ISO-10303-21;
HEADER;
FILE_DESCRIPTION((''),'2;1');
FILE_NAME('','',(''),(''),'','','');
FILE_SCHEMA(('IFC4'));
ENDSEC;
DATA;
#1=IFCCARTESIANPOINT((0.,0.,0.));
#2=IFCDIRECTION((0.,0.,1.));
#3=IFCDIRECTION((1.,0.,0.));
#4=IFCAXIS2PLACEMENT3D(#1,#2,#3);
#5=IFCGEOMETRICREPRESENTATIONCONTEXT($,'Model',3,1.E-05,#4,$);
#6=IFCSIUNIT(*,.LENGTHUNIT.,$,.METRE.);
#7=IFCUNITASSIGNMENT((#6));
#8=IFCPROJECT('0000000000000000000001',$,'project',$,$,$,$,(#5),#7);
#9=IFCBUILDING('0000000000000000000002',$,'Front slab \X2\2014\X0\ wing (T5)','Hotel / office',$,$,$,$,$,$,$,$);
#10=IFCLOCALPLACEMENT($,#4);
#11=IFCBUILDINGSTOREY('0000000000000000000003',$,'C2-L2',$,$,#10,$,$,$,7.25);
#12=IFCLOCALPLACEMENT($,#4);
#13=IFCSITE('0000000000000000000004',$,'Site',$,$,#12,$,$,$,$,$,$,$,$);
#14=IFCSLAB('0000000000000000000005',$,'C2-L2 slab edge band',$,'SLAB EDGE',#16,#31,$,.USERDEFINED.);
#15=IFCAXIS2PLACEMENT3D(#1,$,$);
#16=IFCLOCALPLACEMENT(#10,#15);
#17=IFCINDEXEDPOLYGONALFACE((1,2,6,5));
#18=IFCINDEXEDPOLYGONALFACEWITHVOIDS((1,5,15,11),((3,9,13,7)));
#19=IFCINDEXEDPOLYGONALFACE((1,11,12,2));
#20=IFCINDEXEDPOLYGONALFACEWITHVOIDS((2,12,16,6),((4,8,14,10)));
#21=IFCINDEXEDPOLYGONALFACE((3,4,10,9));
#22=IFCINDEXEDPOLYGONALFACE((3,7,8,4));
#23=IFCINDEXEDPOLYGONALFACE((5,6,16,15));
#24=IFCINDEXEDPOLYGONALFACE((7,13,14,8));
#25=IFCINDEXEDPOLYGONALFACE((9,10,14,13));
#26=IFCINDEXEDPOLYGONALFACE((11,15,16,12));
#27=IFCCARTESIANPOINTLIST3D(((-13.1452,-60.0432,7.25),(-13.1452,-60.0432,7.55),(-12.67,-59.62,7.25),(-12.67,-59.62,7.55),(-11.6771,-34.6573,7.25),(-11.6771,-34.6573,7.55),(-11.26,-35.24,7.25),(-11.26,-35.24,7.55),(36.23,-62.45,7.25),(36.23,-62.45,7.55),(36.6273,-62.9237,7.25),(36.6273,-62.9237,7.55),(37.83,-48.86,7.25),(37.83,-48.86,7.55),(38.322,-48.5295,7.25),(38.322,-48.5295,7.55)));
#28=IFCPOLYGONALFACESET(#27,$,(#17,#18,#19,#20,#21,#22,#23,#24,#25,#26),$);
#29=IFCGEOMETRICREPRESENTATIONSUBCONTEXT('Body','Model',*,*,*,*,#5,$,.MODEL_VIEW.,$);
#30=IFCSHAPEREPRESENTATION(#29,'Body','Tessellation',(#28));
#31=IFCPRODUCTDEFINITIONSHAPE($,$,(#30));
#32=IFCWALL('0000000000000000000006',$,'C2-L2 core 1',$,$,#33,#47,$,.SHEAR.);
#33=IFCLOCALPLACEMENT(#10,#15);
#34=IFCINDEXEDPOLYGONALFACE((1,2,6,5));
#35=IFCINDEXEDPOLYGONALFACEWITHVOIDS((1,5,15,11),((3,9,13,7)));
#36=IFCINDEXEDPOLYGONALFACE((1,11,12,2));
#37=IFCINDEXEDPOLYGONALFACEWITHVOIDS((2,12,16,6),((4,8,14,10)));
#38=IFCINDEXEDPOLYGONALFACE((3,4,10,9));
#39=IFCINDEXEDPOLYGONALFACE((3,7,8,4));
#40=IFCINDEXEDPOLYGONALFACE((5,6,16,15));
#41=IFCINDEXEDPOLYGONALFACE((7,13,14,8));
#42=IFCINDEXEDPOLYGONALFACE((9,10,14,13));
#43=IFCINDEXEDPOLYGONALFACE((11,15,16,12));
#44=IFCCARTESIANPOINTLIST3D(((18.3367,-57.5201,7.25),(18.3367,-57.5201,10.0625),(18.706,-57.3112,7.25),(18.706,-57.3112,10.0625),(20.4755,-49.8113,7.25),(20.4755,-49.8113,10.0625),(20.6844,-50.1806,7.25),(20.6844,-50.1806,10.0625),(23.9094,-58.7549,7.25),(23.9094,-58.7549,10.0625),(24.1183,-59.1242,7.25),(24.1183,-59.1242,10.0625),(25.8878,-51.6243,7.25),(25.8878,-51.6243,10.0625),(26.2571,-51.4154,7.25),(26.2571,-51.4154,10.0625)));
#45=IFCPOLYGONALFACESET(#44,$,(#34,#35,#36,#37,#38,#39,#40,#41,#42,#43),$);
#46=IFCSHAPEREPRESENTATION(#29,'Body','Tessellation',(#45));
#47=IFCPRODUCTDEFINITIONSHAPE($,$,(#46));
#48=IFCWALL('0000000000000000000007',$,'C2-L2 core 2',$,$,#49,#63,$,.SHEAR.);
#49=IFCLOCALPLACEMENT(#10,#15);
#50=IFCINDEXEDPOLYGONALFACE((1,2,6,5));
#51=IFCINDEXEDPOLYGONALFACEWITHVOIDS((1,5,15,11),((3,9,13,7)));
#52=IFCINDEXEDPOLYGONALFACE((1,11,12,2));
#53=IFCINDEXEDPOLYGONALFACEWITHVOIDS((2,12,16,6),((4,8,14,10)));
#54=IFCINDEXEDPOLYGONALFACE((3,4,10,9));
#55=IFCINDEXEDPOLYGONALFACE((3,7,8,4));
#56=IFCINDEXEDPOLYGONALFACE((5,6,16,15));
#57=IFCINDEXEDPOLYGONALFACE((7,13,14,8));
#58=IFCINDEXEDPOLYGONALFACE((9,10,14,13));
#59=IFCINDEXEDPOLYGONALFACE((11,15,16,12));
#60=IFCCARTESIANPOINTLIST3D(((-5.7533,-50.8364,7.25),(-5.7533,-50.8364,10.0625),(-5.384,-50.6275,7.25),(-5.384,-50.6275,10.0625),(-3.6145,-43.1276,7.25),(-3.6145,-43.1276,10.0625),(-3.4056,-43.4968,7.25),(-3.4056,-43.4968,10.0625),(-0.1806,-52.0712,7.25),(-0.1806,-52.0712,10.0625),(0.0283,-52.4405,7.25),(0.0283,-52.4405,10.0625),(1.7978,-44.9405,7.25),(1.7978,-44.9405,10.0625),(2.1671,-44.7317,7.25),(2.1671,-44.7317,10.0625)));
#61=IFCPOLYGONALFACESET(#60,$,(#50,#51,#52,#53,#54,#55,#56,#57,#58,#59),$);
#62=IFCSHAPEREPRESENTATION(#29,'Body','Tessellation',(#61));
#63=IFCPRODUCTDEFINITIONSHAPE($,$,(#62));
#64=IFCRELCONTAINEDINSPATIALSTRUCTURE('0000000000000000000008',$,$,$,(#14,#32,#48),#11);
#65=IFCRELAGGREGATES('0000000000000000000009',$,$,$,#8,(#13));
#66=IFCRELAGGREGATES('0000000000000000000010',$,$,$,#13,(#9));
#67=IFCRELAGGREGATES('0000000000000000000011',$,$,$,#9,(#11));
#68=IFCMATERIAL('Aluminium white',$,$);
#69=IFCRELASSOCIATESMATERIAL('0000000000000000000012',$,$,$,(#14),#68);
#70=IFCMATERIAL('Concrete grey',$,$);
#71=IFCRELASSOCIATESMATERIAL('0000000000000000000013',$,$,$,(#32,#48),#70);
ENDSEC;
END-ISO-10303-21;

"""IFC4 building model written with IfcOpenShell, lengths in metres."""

from ifc_helpers import new_model, si_unit, frame, origin_with_axes, place, context, subcontext, project, spatial, polyline, outline, extrude, material, element, save


model = new_model("IFC4")

# Units and contexts
model_context = context("Model", 3, precision=1e-05, world=origin_with_axes())
body_context = subcontext(model_context, "Body", "Model", "MODEL_VIEW")
ifc_project = project(units=[si_unit("LENGTHUNIT", "METRE")], contexts=[model_context])

# Site, building, storey
site_placement = place(None, origin_with_axes())
site = spatial("IfcSite", under=ifc_project, at=site_placement, Name="Site")
building = spatial("IfcBuilding", under=site, Name="Front slab — wing (T5)", Description="Hotel / office")
storey_placement = place(None, origin_with_axes())
storey = spatial("IfcBuildingStorey", under=building, at=storey_placement, Name="C2-L2", Elevation=7.25)

# Shared definitions
ifc_material_1 = material(Name="Aluminium white")

# Slab
slab_placement = place(storey_placement, origin_with_axes())
element("IfcSlab", 1, at=slab_placement, inside=storey, material=ifc_material_1, Name="C2-L2 slab edge band", ObjectType="SLAB EDGE", PredefinedType="USERDEFINED", context=body_context, shape_type="SweptSolid", body=[
    extrude(outline(polyline([(-11.6771, -34.6573), (-13.1452, -60.0432), (36.6273, -62.9237), (38.322, -48.5295), (-11.6771, -34.6573)]), holes=[polyline([(-11.26, -35.24), (-12.67, -59.62), (36.23, -62.45), (37.83, -48.86), (-11.26, -35.24)])]), frame((0.0, 0.0, 7.25), z_axis=(0.0, 0.0, 1.0), x_axis=(1.0, 0.0, 0.0)), (0.0, 0.0, 1.0), 0.3),
])

# Walls
ifc_material_2 = material(Name="Concrete grey")
wall_1_placement = place(storey_placement, origin_with_axes())
element("IfcWall", 2, at=wall_1_placement, inside=storey, material=ifc_material_2, Name="C2-L2 core 1", PredefinedType="SHEAR", context=body_context, shape_type="SweptSolid", body=[
    extrude(outline(polyline([(26.2571, -51.4154), (20.4755, -49.8113), (18.3367, -57.5201), (24.1183, -59.1242), (26.2571, -51.4154)]), holes=[polyline([(25.8878, -51.6243), (20.6844, -50.1806), (18.706, -57.3112), (23.9094, -58.7549), (25.8878, -51.6243)])]), frame((0.0, 0.0, 7.25), z_axis=(0.0, 0.0, 1.0), x_axis=(1.0, 0.0, 0.0)), (0.0, 0.0, 1.0), 2.8125),
])
wall_2_placement = place(storey_placement, origin_with_axes())
element("IfcWall", 3, at=wall_2_placement, inside=storey, material=ifc_material_2, Name="C2-L2 core 2", PredefinedType="SHEAR", context=body_context, shape_type="SweptSolid", body=[
    extrude(outline(polyline([(2.1671, -44.7317), (-3.6145, -43.1276), (-5.7533, -50.8364), (0.0283, -52.4405), (2.1671, -44.7317)]), holes=[polyline([(1.7978, -44.9405), (-3.4056, -43.4968), (-5.384, -50.6275), (-0.1806, -52.0712), (1.7978, -44.9405)])]), frame((0.0, 0.0, 7.25), z_axis=(0.0, 0.0, 1.0), x_axis=(1.0, 0.0, 0.0)), (0.0, 0.0, 1.0), 2.8125),
])

save(model, "model.ifc")
